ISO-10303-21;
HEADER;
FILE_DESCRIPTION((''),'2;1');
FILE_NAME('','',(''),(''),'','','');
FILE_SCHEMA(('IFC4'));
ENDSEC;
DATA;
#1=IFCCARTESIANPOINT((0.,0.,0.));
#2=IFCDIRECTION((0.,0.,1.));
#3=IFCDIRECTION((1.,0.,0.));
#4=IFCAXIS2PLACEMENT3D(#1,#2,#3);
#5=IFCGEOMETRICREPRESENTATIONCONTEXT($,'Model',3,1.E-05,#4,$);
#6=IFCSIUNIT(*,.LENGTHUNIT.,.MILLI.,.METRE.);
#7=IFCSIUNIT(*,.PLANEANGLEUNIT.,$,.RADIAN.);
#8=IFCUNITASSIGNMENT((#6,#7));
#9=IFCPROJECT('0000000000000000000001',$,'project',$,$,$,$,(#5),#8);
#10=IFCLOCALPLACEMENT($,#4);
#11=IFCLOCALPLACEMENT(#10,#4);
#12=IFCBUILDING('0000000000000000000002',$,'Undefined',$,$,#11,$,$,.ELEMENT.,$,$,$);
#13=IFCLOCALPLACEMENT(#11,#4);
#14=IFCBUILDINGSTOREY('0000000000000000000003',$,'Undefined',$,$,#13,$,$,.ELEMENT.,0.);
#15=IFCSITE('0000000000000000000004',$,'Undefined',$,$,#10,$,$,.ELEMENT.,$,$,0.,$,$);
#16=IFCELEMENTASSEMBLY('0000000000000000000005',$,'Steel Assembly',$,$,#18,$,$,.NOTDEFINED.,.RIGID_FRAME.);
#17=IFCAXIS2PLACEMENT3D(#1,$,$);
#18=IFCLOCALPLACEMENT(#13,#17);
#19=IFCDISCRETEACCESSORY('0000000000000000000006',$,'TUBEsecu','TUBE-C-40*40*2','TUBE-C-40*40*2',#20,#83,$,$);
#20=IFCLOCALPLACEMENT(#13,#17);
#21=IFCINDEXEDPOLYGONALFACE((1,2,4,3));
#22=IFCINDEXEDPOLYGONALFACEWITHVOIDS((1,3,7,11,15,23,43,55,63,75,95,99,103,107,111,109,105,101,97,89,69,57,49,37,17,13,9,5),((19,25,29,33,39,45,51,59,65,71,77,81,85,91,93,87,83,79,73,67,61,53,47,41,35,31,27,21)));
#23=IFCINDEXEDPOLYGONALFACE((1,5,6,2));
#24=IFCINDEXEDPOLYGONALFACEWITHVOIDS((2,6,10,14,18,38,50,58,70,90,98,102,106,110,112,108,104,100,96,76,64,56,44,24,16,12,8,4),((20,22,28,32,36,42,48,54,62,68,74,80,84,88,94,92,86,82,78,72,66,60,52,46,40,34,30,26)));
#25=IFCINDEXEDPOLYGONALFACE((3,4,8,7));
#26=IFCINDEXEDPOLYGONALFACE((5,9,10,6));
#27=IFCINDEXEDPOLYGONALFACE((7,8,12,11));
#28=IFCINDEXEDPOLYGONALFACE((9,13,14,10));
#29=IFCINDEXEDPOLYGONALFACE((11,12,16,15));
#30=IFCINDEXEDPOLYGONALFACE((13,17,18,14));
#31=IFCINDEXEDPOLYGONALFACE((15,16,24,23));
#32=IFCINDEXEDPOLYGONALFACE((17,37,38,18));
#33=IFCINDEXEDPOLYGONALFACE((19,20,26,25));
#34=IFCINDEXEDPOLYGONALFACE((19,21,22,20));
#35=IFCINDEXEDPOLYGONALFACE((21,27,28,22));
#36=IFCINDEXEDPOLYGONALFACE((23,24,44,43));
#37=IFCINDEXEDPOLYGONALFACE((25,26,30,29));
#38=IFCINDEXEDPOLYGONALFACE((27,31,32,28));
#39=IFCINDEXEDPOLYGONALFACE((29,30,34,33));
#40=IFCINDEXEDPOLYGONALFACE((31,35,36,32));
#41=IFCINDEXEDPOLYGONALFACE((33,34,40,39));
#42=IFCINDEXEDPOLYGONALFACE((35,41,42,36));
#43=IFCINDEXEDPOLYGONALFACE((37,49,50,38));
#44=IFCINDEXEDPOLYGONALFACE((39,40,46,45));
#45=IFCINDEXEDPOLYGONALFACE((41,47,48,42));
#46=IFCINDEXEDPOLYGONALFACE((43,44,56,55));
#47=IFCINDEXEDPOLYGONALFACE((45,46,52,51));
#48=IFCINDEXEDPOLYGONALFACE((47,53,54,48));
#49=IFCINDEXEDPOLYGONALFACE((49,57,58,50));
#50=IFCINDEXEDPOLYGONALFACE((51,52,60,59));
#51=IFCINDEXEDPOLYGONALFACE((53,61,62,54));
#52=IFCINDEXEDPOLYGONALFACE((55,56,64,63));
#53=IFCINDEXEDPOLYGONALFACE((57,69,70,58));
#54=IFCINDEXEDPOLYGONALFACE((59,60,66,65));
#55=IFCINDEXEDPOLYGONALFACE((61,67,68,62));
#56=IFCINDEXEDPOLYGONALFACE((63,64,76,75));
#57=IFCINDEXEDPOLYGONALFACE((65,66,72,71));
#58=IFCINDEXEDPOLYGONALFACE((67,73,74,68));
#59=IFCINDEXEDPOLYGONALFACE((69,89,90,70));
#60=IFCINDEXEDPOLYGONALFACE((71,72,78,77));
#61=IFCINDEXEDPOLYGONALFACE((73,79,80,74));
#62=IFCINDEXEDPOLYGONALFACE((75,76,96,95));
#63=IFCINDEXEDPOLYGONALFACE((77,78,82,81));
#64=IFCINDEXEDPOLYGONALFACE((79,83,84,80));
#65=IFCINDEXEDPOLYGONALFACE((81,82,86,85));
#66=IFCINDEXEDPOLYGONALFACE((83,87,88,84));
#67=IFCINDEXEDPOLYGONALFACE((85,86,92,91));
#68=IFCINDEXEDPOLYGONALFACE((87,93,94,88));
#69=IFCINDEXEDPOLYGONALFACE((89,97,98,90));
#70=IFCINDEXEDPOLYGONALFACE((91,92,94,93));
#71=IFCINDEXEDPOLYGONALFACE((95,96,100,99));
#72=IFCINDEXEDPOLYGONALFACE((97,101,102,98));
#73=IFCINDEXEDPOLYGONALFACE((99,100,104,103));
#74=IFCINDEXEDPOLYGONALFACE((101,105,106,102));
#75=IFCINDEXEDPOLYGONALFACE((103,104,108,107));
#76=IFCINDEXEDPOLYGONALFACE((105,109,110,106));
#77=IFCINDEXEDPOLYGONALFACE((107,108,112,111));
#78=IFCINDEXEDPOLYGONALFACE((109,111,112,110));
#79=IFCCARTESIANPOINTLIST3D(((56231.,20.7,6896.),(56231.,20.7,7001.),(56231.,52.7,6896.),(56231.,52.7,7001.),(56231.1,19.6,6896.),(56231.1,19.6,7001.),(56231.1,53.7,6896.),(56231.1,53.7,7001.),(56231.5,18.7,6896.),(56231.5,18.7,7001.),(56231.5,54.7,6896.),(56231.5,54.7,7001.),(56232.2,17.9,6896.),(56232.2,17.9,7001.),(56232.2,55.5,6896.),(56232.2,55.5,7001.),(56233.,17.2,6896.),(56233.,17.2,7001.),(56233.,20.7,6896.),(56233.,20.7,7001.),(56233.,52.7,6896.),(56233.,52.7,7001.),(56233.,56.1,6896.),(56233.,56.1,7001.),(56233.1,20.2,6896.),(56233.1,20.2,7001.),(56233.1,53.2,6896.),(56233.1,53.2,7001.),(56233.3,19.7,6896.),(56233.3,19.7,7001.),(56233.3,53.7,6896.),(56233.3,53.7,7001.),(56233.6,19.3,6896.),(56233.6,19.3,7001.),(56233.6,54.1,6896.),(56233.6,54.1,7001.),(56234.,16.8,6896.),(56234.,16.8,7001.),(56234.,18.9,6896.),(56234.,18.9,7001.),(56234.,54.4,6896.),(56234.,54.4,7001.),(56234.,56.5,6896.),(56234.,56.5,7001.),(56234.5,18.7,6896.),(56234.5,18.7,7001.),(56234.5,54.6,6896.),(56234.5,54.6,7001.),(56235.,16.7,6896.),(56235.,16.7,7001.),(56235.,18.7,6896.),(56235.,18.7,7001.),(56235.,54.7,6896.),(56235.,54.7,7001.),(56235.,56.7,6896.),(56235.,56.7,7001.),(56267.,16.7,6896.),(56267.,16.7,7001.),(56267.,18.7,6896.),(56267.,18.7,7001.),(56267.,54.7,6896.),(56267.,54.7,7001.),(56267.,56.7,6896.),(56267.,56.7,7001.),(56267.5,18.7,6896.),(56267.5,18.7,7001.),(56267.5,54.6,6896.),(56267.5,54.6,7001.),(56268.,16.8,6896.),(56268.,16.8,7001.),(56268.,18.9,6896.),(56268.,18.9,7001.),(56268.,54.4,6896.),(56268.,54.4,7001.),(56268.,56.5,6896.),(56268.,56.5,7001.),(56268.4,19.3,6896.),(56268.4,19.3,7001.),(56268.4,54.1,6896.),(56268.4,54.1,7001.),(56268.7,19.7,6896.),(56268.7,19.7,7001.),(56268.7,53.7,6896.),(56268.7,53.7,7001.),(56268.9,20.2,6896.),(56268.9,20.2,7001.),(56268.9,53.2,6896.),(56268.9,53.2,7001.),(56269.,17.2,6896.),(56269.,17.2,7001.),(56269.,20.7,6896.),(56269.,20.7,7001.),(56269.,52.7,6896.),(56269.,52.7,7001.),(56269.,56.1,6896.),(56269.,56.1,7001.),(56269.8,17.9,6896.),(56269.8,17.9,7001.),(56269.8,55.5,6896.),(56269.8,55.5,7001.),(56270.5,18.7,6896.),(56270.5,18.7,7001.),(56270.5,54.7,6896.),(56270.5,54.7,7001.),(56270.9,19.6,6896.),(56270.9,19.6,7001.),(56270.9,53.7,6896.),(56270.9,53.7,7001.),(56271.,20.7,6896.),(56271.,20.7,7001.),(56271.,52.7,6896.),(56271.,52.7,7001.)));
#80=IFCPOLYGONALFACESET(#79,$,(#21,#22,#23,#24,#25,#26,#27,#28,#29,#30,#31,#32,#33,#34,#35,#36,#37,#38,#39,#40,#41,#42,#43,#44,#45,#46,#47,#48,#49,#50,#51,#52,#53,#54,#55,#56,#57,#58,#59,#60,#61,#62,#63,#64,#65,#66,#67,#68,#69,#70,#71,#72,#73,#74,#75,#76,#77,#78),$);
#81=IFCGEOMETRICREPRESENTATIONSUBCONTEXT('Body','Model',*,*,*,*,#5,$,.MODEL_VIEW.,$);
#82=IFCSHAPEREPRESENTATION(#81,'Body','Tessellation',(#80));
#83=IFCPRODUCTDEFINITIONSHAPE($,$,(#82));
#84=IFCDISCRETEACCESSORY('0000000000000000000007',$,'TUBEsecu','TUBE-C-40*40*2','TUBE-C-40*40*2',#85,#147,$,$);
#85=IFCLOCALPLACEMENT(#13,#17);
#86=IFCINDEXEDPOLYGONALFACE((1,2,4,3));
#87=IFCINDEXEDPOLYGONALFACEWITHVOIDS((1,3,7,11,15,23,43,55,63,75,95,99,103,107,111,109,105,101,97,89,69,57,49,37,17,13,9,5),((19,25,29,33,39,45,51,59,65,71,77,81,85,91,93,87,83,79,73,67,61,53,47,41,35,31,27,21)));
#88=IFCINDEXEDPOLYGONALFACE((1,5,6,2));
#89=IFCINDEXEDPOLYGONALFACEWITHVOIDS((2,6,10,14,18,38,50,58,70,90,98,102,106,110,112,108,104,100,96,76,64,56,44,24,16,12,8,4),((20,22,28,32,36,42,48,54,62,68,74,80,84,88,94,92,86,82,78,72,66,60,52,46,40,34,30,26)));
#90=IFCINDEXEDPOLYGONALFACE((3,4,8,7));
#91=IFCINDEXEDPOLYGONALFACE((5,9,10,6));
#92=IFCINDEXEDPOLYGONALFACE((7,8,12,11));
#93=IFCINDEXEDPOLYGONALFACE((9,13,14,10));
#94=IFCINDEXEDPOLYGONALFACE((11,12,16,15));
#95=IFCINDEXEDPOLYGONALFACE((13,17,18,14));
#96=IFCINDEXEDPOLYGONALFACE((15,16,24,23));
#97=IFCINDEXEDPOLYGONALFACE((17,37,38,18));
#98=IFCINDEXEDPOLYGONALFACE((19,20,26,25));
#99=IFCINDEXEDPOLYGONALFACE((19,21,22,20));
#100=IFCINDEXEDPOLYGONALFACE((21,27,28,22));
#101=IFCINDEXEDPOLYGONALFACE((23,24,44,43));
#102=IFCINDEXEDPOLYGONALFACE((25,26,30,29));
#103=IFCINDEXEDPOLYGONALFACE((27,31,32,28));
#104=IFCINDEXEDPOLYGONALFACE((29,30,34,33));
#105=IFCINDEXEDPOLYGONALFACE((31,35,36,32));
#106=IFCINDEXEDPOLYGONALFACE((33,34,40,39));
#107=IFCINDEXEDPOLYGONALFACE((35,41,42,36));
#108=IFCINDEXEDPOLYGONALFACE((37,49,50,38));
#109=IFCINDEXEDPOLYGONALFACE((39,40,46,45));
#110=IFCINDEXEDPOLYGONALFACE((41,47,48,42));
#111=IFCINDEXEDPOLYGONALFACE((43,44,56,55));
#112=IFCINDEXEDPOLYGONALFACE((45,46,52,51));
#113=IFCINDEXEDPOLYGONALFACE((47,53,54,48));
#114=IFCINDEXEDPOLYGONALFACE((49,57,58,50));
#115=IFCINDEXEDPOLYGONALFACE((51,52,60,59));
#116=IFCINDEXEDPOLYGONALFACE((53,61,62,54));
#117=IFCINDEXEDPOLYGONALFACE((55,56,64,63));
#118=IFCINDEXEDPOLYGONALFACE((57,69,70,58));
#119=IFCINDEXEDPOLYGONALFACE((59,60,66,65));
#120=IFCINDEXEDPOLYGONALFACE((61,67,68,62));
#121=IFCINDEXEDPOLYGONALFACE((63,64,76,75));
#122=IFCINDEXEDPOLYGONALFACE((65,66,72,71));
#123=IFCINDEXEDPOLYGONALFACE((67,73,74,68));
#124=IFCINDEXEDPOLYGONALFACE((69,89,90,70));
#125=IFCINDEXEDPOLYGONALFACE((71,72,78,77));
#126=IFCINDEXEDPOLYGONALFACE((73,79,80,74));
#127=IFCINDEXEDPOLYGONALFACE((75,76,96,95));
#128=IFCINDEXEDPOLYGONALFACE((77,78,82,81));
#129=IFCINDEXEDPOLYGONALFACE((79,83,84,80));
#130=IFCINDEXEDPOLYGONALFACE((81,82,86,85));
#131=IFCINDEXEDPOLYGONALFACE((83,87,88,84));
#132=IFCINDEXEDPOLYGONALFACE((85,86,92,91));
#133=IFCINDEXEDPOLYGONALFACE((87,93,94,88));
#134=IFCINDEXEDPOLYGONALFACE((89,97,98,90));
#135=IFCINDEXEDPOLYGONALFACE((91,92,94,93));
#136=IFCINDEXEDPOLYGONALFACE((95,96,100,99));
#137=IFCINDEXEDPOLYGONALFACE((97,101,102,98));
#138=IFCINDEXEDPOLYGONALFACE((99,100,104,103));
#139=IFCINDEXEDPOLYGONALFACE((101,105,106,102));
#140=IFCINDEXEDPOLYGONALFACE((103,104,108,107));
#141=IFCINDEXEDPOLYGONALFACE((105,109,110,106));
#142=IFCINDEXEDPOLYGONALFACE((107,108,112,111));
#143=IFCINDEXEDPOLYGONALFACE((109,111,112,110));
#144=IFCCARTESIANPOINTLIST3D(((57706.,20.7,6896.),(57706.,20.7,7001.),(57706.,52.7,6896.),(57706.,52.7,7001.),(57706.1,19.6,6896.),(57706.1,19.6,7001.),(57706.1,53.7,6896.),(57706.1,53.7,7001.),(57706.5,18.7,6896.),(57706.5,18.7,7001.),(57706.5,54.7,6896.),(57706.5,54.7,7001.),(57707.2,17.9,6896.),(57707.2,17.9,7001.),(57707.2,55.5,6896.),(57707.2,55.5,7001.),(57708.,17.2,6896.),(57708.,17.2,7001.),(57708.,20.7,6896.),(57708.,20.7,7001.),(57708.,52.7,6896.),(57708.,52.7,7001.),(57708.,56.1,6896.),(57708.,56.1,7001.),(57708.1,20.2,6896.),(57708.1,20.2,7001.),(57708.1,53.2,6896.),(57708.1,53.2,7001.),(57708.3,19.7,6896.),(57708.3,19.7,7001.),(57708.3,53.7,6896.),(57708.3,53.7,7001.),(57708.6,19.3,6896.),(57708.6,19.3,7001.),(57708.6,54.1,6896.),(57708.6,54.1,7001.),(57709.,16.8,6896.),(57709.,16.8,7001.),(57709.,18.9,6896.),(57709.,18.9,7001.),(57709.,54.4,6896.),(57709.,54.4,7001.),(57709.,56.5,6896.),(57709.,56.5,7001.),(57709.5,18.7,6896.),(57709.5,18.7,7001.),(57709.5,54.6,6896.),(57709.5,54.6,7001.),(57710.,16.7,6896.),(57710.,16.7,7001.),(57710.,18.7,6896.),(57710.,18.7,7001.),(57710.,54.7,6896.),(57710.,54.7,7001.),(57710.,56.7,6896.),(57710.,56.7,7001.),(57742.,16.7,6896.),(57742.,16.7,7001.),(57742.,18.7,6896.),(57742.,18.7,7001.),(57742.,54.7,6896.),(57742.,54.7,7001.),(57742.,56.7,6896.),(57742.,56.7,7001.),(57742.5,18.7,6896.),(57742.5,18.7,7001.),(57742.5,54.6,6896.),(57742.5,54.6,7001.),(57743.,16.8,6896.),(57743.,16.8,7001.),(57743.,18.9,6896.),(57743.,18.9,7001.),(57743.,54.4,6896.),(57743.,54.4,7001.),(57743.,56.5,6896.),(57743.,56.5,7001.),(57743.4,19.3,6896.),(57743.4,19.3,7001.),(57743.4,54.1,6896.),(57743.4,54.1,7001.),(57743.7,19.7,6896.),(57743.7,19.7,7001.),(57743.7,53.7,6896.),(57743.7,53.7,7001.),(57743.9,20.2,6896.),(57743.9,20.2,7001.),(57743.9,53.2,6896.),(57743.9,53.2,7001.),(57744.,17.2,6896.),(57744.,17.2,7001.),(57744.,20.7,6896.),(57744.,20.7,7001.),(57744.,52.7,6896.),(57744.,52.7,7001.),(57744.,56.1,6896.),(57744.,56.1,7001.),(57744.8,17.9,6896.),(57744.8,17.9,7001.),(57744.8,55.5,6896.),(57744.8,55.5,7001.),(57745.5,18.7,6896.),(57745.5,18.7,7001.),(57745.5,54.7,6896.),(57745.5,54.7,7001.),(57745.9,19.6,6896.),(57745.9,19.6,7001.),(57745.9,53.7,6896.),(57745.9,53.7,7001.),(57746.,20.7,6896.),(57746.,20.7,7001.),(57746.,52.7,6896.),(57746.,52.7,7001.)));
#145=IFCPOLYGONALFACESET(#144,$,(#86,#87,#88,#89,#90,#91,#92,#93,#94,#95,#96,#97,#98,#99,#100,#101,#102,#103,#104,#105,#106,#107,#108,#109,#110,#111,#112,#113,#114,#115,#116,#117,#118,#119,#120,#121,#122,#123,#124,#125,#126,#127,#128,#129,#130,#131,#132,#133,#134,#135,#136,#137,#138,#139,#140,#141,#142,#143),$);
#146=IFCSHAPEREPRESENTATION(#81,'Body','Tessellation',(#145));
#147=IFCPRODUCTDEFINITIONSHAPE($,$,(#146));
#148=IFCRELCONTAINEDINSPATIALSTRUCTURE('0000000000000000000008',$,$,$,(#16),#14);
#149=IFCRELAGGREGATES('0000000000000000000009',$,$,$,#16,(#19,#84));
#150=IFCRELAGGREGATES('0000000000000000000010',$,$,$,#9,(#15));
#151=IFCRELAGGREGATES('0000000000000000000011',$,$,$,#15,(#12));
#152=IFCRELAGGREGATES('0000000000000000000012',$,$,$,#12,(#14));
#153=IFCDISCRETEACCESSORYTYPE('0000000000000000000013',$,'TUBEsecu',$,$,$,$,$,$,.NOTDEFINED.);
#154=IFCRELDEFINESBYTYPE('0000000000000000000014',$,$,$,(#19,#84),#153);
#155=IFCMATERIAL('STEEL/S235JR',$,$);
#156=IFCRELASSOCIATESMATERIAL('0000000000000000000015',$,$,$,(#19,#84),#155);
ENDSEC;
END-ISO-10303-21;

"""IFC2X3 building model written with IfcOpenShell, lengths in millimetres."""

from ifc_helpers import new_model, si_unit, frame, origin_with_axes, origin_2d_with_axis, place, context, subcontext, project, spatial, hollow_rectangle, extrude, material, type_object, element, aggregate, save


model = new_model("IFC2X3")

# Units and contexts
model_context = context("Model", 3, precision=1e-05, world=origin_with_axes())
body_context = subcontext(model_context, "Body", "Model", "MODEL_VIEW")
ifc_project = project(units=[si_unit("LENGTHUNIT", "METRE", prefix="MILLI"), si_unit("PLANEANGLEUNIT", "RADIAN")], contexts=[model_context])

# Site, building, storey
site_placement = place(None, origin_with_axes())
site = spatial("IfcSite", under=ifc_project, at=site_placement, Name="Undefined", CompositionType="ELEMENT", RefElevation=0.0)
building_placement = place(site_placement, origin_with_axes())
building = spatial("IfcBuilding", under=site, at=building_placement, Name="Undefined", CompositionType="ELEMENT")
storey_placement = place(building_placement, origin_with_axes())
storey = spatial("IfcBuildingStorey", under=building, at=storey_placement, Name="Undefined", CompositionType="ELEMENT", Elevation=0.0)

# Element assembly
ifc_material_1 = material(Name="STEEL/S235JR")
assembly_1_placement = place(storey_placement, origin_with_axes())
assembly_1 = element("IfcElementAssembly", 1, at=assembly_1_placement, inside=storey, Name="Steel Assembly", AssemblyPlace="NOTDEFINED", PredefinedType="RIGID_FRAME")

# Discrete accessories
discrete_accessory_type_1 = type_object("IfcDiscreteAccessoryType", Name="TUBEsecu")
discrete_accessory_1_placement = place(assembly_1_placement, frame((56251.0, 36.7, 6896.0), z_axis=(0.0, 0.0, 1.0), x_axis=(1.0, 0.0, 0.0)))
discrete_accessory_1 = element("IfcDiscreteAccessory", 2, at=discrete_accessory_1_placement, type_object=discrete_accessory_type_1, material=ifc_material_1, Name="TUBEsecu", Description="TUBE-C-40*40*2", ObjectType="TUBE-C-40*40*2", context=body_context, shape_type="SweptSolid", body=[
    extrude(hollow_rectangle(XDim=40.0, YDim=40.0, WallThickness=2.0, InnerFilletRadius=2.0, OuterFilletRadius=4.0, at=origin_2d_with_axis()), frame((0.0, 0.0, 105.0), z_axis=(0.0, 0.0, -1.0), x_axis=(0.0, -1.0, 0.0)), (0.0, 0.0, 1.0), 105.0),
])
discrete_accessory_2_placement = place(assembly_1_placement, frame((57726.0, 36.7, 6896.0), z_axis=(0.0, 0.0, 1.0), x_axis=(1.0, 0.0, 0.0)))
discrete_accessory_2 = element("IfcDiscreteAccessory", 3, at=discrete_accessory_2_placement, type_object=discrete_accessory_type_1, material=ifc_material_1, Name="TUBEsecu", Description="TUBE-C-40*40*2", ObjectType="TUBE-C-40*40*2", context=body_context, shape_type="SweptSolid", body=[
    extrude(hollow_rectangle(XDim=40.0, YDim=40.0, WallThickness=2.0, InnerFilletRadius=2.0, OuterFilletRadius=4.0, at=origin_2d_with_axis()), frame((0.0, 0.0, 105.0), z_axis=(0.0, 0.0, -1.0), x_axis=(0.0, -1.0, 0.0)), (0.0, 0.0, 1.0), 105.0),
])
aggregate(assembly_1, [discrete_accessory_1, discrete_accessory_2])

save(model, "model.ifc")
